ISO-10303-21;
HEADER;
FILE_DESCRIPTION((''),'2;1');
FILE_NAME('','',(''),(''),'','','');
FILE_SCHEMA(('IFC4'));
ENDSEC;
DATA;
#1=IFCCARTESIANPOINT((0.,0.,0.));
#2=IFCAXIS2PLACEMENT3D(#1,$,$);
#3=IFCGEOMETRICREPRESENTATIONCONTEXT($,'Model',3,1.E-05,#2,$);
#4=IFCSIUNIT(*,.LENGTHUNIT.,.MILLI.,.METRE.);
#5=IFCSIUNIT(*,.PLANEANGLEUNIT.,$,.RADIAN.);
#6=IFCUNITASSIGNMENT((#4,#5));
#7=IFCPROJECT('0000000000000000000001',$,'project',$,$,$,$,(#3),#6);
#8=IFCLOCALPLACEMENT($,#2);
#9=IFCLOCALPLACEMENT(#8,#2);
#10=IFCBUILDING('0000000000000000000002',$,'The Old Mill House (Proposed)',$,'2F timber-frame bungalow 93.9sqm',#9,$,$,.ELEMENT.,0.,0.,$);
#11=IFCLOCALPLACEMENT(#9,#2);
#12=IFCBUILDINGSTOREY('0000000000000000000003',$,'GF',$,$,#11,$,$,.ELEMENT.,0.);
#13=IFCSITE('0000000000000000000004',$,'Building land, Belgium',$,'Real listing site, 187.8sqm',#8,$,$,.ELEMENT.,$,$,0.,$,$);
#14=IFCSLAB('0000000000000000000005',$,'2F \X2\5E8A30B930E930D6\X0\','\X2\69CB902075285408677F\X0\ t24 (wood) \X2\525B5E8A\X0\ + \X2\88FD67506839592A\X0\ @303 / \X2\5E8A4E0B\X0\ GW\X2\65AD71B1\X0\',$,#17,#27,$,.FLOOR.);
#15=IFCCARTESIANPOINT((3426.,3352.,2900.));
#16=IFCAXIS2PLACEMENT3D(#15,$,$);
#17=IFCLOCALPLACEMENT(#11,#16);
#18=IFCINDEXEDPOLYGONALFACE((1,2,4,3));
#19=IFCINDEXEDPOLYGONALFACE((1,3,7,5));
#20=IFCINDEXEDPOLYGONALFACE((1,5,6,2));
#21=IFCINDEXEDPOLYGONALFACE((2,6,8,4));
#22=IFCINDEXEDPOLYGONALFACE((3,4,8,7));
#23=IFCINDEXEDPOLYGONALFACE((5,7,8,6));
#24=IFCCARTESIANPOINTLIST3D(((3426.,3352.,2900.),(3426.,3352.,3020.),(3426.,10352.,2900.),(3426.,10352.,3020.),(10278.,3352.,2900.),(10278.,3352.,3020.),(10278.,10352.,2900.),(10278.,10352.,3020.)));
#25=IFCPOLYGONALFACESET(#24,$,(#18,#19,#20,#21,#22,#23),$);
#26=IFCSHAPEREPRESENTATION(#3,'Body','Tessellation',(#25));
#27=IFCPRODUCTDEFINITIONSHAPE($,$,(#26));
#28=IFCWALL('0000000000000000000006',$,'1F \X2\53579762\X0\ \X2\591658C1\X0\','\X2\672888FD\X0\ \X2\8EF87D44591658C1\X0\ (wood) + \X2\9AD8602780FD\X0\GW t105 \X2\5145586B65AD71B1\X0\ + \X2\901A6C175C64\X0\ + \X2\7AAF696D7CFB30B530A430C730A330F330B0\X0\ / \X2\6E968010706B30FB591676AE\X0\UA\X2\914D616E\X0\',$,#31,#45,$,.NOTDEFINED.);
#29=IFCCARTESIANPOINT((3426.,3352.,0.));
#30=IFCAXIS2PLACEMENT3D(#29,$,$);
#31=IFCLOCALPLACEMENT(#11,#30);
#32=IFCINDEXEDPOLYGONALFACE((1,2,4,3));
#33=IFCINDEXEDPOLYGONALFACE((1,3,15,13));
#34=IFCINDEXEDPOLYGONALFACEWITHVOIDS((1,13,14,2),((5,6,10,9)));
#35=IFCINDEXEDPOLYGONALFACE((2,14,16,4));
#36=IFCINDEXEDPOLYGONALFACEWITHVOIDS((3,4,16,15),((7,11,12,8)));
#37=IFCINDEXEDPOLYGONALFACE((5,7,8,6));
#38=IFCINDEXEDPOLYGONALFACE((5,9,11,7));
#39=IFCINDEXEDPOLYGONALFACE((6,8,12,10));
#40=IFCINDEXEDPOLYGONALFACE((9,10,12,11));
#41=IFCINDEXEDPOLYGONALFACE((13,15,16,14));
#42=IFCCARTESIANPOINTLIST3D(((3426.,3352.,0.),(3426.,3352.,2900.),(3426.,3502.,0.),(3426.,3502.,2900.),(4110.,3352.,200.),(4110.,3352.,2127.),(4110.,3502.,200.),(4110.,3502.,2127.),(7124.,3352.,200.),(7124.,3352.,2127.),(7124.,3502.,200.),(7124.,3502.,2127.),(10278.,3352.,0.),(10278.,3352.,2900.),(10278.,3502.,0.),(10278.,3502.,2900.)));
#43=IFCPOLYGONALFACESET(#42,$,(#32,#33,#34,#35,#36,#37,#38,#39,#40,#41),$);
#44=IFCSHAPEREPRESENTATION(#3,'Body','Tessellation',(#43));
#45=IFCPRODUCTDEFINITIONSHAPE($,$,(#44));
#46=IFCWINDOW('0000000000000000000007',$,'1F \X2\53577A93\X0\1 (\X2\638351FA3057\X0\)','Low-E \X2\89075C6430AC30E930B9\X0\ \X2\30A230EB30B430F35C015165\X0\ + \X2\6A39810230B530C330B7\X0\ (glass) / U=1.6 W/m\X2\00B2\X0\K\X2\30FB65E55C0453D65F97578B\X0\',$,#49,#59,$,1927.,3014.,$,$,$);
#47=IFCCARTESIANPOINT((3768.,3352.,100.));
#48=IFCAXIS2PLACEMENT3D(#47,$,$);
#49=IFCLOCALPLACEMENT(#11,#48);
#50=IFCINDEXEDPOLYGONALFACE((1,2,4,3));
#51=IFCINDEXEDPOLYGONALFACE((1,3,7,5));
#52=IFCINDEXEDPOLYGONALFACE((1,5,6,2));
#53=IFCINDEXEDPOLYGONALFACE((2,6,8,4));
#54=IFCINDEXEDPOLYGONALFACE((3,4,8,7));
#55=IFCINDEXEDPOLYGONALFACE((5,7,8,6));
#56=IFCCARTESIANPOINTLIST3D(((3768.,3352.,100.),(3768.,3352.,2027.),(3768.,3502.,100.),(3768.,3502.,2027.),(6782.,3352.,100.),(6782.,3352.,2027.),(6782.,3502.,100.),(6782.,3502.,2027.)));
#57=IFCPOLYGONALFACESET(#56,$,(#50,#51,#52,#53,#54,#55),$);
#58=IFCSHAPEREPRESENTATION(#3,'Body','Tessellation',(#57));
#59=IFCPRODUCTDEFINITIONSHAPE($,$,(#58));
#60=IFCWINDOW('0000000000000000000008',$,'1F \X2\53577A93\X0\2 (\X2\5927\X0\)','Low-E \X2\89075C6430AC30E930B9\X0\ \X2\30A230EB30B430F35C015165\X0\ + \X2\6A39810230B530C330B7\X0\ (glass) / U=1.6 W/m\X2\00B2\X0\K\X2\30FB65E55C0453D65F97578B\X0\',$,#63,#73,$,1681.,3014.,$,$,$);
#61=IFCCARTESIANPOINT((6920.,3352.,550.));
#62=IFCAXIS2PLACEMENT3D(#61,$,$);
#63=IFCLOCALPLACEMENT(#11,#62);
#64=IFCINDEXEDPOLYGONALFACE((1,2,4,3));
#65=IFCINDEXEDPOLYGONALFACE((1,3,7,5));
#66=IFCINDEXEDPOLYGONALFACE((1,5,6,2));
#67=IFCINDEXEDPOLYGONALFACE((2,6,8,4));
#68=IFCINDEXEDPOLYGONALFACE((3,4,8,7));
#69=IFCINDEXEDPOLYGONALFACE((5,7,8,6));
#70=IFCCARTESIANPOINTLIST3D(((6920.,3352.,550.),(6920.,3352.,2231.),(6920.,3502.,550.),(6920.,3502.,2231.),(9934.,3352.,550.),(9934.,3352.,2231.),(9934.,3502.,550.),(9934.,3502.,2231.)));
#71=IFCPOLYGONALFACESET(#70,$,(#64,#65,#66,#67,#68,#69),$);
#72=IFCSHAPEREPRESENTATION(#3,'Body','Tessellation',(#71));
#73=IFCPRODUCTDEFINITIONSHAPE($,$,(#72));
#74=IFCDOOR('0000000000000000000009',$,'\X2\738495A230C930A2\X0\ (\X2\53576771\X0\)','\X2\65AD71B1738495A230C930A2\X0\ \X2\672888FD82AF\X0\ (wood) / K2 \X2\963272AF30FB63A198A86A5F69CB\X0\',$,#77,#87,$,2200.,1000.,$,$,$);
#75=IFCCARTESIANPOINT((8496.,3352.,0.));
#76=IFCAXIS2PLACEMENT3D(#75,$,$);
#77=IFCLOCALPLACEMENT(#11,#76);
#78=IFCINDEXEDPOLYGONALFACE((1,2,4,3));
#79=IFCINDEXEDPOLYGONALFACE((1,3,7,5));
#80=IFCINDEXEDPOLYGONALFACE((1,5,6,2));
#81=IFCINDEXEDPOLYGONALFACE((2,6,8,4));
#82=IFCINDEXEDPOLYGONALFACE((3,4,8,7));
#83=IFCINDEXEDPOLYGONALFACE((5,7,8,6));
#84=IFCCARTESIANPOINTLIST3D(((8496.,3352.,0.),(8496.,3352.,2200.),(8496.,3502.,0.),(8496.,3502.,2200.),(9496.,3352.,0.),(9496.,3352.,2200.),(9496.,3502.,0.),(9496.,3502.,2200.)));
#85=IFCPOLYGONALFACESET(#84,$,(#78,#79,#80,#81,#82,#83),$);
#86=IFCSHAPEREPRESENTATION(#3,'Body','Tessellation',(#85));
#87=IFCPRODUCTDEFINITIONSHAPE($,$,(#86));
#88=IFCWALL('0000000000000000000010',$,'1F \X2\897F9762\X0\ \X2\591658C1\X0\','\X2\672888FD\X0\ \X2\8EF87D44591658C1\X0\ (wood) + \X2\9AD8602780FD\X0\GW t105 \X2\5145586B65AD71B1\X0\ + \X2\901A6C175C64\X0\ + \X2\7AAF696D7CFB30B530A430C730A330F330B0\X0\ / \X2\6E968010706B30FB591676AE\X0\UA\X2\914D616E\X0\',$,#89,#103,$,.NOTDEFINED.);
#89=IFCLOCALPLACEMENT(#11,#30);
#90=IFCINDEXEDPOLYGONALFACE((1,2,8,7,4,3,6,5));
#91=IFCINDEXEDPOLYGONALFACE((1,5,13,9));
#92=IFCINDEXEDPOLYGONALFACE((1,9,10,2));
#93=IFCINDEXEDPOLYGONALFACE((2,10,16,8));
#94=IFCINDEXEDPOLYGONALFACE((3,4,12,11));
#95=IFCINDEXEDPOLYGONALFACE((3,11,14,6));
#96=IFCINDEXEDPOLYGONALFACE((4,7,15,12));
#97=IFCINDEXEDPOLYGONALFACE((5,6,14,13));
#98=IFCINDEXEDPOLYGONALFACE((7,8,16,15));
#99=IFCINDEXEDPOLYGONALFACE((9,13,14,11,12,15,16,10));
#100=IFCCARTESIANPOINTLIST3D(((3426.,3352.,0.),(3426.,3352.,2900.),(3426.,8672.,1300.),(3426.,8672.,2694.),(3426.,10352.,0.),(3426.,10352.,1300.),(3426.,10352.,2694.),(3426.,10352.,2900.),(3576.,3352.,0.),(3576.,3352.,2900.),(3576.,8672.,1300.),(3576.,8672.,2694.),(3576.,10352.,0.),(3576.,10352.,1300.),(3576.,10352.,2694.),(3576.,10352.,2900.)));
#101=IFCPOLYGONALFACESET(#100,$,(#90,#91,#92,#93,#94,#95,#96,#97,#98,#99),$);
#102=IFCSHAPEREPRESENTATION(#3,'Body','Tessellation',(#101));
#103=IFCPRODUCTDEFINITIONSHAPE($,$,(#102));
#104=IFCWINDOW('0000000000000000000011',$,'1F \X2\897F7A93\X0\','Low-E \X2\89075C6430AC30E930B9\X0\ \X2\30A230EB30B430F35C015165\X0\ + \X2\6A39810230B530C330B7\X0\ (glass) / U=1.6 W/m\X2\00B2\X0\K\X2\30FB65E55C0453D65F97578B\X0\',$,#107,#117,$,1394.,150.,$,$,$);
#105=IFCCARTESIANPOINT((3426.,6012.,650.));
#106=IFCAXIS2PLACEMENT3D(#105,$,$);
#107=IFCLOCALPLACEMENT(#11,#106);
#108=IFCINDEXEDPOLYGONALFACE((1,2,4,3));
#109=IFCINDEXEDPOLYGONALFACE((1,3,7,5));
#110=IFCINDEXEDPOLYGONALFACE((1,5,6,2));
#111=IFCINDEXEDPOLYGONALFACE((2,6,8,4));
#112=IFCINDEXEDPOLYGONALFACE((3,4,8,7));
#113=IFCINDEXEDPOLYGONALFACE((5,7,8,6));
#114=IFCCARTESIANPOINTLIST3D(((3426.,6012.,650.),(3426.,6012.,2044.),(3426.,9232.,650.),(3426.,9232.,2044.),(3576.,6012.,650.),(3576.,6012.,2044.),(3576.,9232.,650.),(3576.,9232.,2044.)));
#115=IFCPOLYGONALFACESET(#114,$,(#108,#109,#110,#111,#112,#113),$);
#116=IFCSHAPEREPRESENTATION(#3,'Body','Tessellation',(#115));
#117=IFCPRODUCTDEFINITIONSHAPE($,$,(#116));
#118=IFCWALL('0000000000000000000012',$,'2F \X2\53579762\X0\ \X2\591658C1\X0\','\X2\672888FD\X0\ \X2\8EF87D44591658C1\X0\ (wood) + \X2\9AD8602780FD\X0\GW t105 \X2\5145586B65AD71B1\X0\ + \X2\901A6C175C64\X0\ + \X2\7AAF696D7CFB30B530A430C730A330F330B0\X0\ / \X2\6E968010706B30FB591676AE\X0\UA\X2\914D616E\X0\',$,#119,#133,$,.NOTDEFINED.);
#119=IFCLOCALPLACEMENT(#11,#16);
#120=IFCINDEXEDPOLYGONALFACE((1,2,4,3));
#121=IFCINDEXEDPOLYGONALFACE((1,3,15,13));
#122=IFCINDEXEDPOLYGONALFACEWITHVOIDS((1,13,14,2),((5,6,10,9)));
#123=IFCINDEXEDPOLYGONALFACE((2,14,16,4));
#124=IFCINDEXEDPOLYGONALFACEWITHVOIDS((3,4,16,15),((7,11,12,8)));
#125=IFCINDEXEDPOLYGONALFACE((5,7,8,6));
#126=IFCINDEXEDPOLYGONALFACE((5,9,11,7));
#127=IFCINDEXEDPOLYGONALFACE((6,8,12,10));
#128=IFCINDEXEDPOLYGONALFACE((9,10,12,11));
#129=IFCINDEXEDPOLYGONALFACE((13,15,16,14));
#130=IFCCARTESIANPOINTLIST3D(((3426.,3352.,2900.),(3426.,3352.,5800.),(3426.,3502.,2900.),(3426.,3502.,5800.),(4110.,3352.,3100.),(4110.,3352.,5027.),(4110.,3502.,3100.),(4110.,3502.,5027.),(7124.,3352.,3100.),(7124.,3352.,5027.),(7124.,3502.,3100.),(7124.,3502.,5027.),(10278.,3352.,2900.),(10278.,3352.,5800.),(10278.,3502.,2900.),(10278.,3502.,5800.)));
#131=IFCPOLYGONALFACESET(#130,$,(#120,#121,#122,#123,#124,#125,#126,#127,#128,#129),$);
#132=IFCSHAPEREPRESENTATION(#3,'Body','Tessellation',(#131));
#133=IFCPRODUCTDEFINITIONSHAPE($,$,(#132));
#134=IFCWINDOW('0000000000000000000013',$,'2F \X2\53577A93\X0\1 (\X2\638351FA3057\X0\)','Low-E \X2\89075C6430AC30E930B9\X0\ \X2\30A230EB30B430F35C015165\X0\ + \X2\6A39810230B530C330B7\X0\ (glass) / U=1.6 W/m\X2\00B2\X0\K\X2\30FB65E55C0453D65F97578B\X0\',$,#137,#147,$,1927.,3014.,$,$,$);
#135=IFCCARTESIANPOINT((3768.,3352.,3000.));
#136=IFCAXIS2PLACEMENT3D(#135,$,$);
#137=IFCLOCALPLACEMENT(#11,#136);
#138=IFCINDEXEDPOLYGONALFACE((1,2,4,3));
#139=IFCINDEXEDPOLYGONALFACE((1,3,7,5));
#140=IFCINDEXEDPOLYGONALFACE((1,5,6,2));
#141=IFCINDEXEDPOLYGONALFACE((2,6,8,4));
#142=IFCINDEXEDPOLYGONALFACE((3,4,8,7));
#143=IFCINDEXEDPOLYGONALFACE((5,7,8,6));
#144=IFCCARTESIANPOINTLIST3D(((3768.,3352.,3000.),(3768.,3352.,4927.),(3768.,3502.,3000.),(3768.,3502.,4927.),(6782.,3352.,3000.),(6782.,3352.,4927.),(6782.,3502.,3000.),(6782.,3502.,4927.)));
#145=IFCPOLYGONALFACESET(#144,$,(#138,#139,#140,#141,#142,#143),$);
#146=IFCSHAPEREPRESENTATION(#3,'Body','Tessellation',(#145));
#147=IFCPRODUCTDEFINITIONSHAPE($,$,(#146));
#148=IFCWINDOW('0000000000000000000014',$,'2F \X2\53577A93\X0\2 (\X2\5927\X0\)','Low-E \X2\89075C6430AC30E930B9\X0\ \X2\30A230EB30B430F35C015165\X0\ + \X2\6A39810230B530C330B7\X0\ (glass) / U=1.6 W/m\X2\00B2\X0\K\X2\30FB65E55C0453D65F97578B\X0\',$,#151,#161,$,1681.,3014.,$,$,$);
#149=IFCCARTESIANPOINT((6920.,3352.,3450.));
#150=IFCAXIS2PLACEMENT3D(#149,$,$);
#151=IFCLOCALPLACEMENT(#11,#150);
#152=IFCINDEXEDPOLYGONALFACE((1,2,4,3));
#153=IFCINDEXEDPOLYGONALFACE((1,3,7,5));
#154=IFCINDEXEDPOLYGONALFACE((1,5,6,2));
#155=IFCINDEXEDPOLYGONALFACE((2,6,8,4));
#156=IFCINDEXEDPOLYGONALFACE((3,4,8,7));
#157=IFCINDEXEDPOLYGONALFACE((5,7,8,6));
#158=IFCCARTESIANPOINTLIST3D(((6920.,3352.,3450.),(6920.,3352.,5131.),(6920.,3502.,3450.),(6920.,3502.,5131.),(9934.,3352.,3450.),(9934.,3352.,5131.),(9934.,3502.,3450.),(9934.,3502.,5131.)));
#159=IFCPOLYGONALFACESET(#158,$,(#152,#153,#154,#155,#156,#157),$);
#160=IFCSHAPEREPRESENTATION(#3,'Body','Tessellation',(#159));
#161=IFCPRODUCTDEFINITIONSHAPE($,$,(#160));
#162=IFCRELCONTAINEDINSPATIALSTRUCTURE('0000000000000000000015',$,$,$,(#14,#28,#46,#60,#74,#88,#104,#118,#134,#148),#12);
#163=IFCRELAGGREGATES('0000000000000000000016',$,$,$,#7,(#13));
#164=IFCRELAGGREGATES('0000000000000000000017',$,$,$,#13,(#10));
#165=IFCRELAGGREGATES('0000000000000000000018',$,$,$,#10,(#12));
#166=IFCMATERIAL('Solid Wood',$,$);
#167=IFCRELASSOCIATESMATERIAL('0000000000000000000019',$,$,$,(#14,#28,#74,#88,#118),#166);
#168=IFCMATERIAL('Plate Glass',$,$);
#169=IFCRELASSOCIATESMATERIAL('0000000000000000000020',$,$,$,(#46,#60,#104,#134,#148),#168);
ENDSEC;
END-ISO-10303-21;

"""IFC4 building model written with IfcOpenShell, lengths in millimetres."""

from ifc_helpers import new_model, si_unit, frame, frame_2d, origin, place, context, project, spatial, rectangle, extrude, material, element, fill, save


model = new_model("IFC4")

# Units and contexts
model_context = context("Model", 3, precision=1e-05, world=origin())
ifc_project = project(units=[si_unit("LENGTHUNIT", "METRE", prefix="MILLI"), si_unit("PLANEANGLEUNIT", "RADIAN")], contexts=[model_context])

# Site, building, storey
site_placement = place(None, origin())
site = spatial("IfcSite", under=ifc_project, at=site_placement, Name="Building land, Belgium", ObjectType="Real listing site, 187.8sqm", CompositionType="ELEMENT", RefElevation=0.0)
building_placement = place(site_placement, origin())
building = spatial("IfcBuilding", under=site, at=building_placement, Name="The Old Mill House (Proposed)", ObjectType="2F timber-frame bungalow 93.9sqm", CompositionType="ELEMENT", ElevationOfRefHeight=0.0, ElevationOfTerrain=0.0)
storey_placement = place(building_placement, origin())
storey = spatial("IfcBuildingStorey", under=building, at=storey_placement, Name="GF", CompositionType="ELEMENT", Elevation=0.0)

# Slab
ifc_material_1 = material(Name="Solid Wood")
slab_1_placement = place(storey_placement, frame((3426.0, 3352.0, 2900.0)))
element("IfcSlab", 1, at=slab_1_placement, inside=storey, material=ifc_material_1, Name="2F 床スラブ", Description="構造用合板 t24 (wood) 剛床 + 製材根太 @303 / 床下 GW断熱", PredefinedType="FLOOR", context=model_context, shape_type="SweptSolid", body=[
    extrude(rectangle(XDim=6852.0, YDim=7000.0, at=frame_2d((3426.0, 3500.0))), frame((3426.0, 3352.0, 2900.0)), (0.0, 0.0, 1.0), 120.0),
])

# Wall, openings, windows, door
wall_1_placement = place(storey_placement, frame((3426.0, 3352.0, 0.0)))
wall_1 = element("IfcWall", 2, at=wall_1_placement, inside=storey, material=ifc_material_1, Name="1F 南面 外壁", Description="木製 軸組外壁 (wood) + 高性能GW t105 充填断熱 + 通気層 + 窯業系サイディング / 準耐火・外皮UA配慮", PredefinedType="NOTDEFINED", context=model_context, shape_type="SweptSolid", body=[
    extrude(rectangle(XDim=6852.0, YDim=150.0, at=frame_2d((3426.0, 75.0))), frame((3426.0, 3352.0, 0.0)), (0.0, 0.0, 1.0), 2900.0),
])
opening_1_placement = place(storey_placement, frame((3768.0, 3352.0, 100.0)))
opening_1 = element("IfcOpeningElement", 3, at=opening_1_placement, cuts=wall_1, PredefinedType="NOTDEFINED", context=model_context, shape_type="SweptSolid", body=[
    extrude(rectangle(XDim=3014.0, YDim=150.0, at=frame_2d((1507.0, 75.0))), frame((3768.0, 3352.0, 100.0)), (0.0, 0.0, 1.0), 1927.0),
])
opening_2_placement = place(storey_placement, frame((6920.0, 3352.0, 550.0)))
opening_2 = element("IfcOpeningElement", 4, at=opening_2_placement, cuts=wall_1, PredefinedType="NOTDEFINED", context=model_context, shape_type="SweptSolid", body=[
    extrude(rectangle(XDim=3014.0, YDim=150.0, at=frame_2d((1507.0, 75.0))), frame((6920.0, 3352.0, 550.0)), (0.0, 0.0, 1.0), 1681.0),
])
opening_3_placement = place(storey_placement, frame((8496.0, 3352.0, 0.0)))
opening_3 = element("IfcOpeningElement", 5, at=opening_3_placement, cuts=wall_1, PredefinedType="NOTDEFINED", context=model_context, shape_type="SweptSolid", body=[
    extrude(rectangle(XDim=1000.0, YDim=150.0, at=frame_2d((500.0, 75.0))), frame((8496.0, 3352.0, 0.0)), (0.0, 0.0, 1.0), 2200.0),
])
ifc_material_2 = material(Name="Plate Glass")
window_1_placement = place(storey_placement, frame((3768.0, 3352.0, 100.0)))
window_1 = element("IfcWindow", 6, at=window_1_placement, inside=storey, material=ifc_material_2, Name="1F 南窓1 (掃出し)", Description="Low-E 複層ガラス アルゴン封入 + 樹脂サッシ (glass) / U=1.6 W/m²K・日射取得型", OverallHeight=1927.0, OverallWidth=3014.0, context=model_context, shape_type="SweptSolid", body=[
    extrude(rectangle(XDim=3014.0, YDim=150.0, at=frame_2d((1507.0, 75.0))), frame((3768.0, 3352.0, 100.0)), (0.0, 0.0, 1.0), 1927.0),
])
fill(opening_1, window_1)
window_2_placement = place(storey_placement, frame((6920.0, 3352.0, 550.0)))
window_2 = element("IfcWindow", 7, at=window_2_placement, inside=storey, material=ifc_material_2, Name="1F 南窓2 (大)", Description="Low-E 複層ガラス アルゴン封入 + 樹脂サッシ (glass) / U=1.6 W/m²K・日射取得型", OverallHeight=1681.0, OverallWidth=3014.0, context=model_context, shape_type="SweptSolid", body=[
    extrude(rectangle(XDim=3014.0, YDim=150.0, at=frame_2d((1507.0, 75.0))), frame((6920.0, 3352.0, 550.0)), (0.0, 0.0, 1.0), 1681.0),
])
fill(opening_2, window_2)
door_placement = place(storey_placement, frame((8496.0, 3352.0, 0.0)))
door = element("IfcDoor", 8, at=door_placement, inside=storey, material=ifc_material_1, Name="玄関ドア (南東)", Description="断熱玄関ドア 木製芯 (wood) / K2 防犯・採風機構", OverallHeight=2200.0, OverallWidth=1000.0, context=model_context, shape_type="SweptSolid", body=[
    extrude(rectangle(XDim=1000.0, YDim=150.0, at=frame_2d((500.0, 75.0))), frame((8496.0, 3352.0, 0.0)), (0.0, 0.0, 1.0), 2200.0),
])
fill(opening_3, door)

# Wall, opening, window
wall_2_placement = place(storey_placement, frame((3426.0, 3352.0, 0.0)))
wall_2 = element("IfcWall", 9, at=wall_2_placement, inside=storey, material=ifc_material_1, Name="1F 西面 外壁", Description="木製 軸組外壁 (wood) + 高性能GW t105 充填断熱 + 通気層 + 窯業系サイディング / 準耐火・外皮UA配慮", PredefinedType="NOTDEFINED", context=model_context, shape_type="SweptSolid", body=[
    extrude(rectangle(XDim=150.0, YDim=7000.0, at=frame_2d((75.0, 3500.0))), frame((3426.0, 3352.0, 0.0)), (0.0, 0.0, 1.0), 2900.0),
])
opening_4_placement = place(storey_placement, frame((3426.0, 6012.0, 650.0)))
opening_4 = element("IfcOpeningElement", 10, at=opening_4_placement, cuts=wall_2, PredefinedType="NOTDEFINED", context=model_context, shape_type="SweptSolid", body=[
    extrude(rectangle(XDim=150.0, YDim=3220.0, at=frame_2d((75.0, 1610.0))), frame((3426.0, 6012.0, 650.0)), (0.0, 0.0, 1.0), 1394.0),
])
window_3_placement = place(storey_placement, frame((3426.0, 6012.0, 650.0)))
window_3 = element("IfcWindow", 11, at=window_3_placement, inside=storey, material=ifc_material_2, Name="1F 西窓", Description="Low-E 複層ガラス アルゴン封入 + 樹脂サッシ (glass) / U=1.6 W/m²K・日射取得型", OverallHeight=1394.0, OverallWidth=150.0, context=model_context, shape_type="SweptSolid", body=[
    extrude(rectangle(XDim=150.0, YDim=3220.0, at=frame_2d((75.0, 1610.0))), frame((3426.0, 6012.0, 650.0)), (0.0, 0.0, 1.0), 1394.0),
])
fill(opening_4, window_3)

# Wall, openings, windows
wall_3_placement = place(storey_placement, frame((3426.0, 3352.0, 2900.0)))
wall_3 = element("IfcWall", 12, at=wall_3_placement, inside=storey, material=ifc_material_1, Name="2F 南面 外壁", Description="木製 軸組外壁 (wood) + 高性能GW t105 充填断熱 + 通気層 + 窯業系サイディング / 準耐火・外皮UA配慮", PredefinedType="NOTDEFINED", context=model_context, shape_type="SweptSolid", body=[
    extrude(rectangle(XDim=6852.0, YDim=150.0, at=frame_2d((3426.0, 75.0))), frame((3426.0, 3352.0, 2900.0)), (0.0, 0.0, 1.0), 2900.0),
])
opening_5_placement = place(storey_placement, frame((3768.0, 3352.0, 3000.0)))
opening_5 = element("IfcOpeningElement", 13, at=opening_5_placement, cuts=wall_3, PredefinedType="NOTDEFINED", context=model_context, shape_type="SweptSolid", body=[
    extrude(rectangle(XDim=3014.0, YDim=150.0, at=frame_2d((1507.0, 75.0))), frame((3768.0, 3352.0, 3000.0)), (0.0, 0.0, 1.0), 1927.0),
])
opening_6_placement = place(storey_placement, frame((6920.0, 3352.0, 3450.0)))
opening_6 = element("IfcOpeningElement", 14, at=opening_6_placement, cuts=wall_3, PredefinedType="NOTDEFINED", context=model_context, shape_type="SweptSolid", body=[
    extrude(rectangle(XDim=3014.0, YDim=150.0, at=frame_2d((1507.0, 75.0))), frame((6920.0, 3352.0, 3450.0)), (0.0, 0.0, 1.0), 1681.0),
])
window_4_placement = place(storey_placement, frame((3768.0, 3352.0, 3000.0)))
window_4 = element("IfcWindow", 15, at=window_4_placement, inside=storey, material=ifc_material_2, Name="2F 南窓1 (掃出し)", Description="Low-E 複層ガラス アルゴン封入 + 樹脂サッシ (glass) / U=1.6 W/m²K・日射取得型", OverallHeight=1927.0, OverallWidth=3014.0, context=model_context, shape_type="SweptSolid", body=[
    extrude(rectangle(XDim=3014.0, YDim=150.0, at=frame_2d((1507.0, 75.0))), frame((3768.0, 3352.0, 3000.0)), (0.0, 0.0, 1.0), 1927.0),
])
fill(opening_5, window_4)
window_5_placement = place(storey_placement, frame((6920.0, 3352.0, 3450.0)))
window_5 = element("IfcWindow", 16, at=window_5_placement, inside=storey, material=ifc_material_2, Name="2F 南窓2 (大)", Description="Low-E 複層ガラス アルゴン封入 + 樹脂サッシ (glass) / U=1.6 W/m²K・日射取得型", OverallHeight=1681.0, OverallWidth=3014.0, context=model_context, shape_type="SweptSolid", body=[
    extrude(rectangle(XDim=3014.0, YDim=150.0, at=frame_2d((1507.0, 75.0))), frame((6920.0, 3352.0, 3450.0)), (0.0, 0.0, 1.0), 1681.0),
])
fill(opening_6, window_5)

save(model, "model.ifc")
